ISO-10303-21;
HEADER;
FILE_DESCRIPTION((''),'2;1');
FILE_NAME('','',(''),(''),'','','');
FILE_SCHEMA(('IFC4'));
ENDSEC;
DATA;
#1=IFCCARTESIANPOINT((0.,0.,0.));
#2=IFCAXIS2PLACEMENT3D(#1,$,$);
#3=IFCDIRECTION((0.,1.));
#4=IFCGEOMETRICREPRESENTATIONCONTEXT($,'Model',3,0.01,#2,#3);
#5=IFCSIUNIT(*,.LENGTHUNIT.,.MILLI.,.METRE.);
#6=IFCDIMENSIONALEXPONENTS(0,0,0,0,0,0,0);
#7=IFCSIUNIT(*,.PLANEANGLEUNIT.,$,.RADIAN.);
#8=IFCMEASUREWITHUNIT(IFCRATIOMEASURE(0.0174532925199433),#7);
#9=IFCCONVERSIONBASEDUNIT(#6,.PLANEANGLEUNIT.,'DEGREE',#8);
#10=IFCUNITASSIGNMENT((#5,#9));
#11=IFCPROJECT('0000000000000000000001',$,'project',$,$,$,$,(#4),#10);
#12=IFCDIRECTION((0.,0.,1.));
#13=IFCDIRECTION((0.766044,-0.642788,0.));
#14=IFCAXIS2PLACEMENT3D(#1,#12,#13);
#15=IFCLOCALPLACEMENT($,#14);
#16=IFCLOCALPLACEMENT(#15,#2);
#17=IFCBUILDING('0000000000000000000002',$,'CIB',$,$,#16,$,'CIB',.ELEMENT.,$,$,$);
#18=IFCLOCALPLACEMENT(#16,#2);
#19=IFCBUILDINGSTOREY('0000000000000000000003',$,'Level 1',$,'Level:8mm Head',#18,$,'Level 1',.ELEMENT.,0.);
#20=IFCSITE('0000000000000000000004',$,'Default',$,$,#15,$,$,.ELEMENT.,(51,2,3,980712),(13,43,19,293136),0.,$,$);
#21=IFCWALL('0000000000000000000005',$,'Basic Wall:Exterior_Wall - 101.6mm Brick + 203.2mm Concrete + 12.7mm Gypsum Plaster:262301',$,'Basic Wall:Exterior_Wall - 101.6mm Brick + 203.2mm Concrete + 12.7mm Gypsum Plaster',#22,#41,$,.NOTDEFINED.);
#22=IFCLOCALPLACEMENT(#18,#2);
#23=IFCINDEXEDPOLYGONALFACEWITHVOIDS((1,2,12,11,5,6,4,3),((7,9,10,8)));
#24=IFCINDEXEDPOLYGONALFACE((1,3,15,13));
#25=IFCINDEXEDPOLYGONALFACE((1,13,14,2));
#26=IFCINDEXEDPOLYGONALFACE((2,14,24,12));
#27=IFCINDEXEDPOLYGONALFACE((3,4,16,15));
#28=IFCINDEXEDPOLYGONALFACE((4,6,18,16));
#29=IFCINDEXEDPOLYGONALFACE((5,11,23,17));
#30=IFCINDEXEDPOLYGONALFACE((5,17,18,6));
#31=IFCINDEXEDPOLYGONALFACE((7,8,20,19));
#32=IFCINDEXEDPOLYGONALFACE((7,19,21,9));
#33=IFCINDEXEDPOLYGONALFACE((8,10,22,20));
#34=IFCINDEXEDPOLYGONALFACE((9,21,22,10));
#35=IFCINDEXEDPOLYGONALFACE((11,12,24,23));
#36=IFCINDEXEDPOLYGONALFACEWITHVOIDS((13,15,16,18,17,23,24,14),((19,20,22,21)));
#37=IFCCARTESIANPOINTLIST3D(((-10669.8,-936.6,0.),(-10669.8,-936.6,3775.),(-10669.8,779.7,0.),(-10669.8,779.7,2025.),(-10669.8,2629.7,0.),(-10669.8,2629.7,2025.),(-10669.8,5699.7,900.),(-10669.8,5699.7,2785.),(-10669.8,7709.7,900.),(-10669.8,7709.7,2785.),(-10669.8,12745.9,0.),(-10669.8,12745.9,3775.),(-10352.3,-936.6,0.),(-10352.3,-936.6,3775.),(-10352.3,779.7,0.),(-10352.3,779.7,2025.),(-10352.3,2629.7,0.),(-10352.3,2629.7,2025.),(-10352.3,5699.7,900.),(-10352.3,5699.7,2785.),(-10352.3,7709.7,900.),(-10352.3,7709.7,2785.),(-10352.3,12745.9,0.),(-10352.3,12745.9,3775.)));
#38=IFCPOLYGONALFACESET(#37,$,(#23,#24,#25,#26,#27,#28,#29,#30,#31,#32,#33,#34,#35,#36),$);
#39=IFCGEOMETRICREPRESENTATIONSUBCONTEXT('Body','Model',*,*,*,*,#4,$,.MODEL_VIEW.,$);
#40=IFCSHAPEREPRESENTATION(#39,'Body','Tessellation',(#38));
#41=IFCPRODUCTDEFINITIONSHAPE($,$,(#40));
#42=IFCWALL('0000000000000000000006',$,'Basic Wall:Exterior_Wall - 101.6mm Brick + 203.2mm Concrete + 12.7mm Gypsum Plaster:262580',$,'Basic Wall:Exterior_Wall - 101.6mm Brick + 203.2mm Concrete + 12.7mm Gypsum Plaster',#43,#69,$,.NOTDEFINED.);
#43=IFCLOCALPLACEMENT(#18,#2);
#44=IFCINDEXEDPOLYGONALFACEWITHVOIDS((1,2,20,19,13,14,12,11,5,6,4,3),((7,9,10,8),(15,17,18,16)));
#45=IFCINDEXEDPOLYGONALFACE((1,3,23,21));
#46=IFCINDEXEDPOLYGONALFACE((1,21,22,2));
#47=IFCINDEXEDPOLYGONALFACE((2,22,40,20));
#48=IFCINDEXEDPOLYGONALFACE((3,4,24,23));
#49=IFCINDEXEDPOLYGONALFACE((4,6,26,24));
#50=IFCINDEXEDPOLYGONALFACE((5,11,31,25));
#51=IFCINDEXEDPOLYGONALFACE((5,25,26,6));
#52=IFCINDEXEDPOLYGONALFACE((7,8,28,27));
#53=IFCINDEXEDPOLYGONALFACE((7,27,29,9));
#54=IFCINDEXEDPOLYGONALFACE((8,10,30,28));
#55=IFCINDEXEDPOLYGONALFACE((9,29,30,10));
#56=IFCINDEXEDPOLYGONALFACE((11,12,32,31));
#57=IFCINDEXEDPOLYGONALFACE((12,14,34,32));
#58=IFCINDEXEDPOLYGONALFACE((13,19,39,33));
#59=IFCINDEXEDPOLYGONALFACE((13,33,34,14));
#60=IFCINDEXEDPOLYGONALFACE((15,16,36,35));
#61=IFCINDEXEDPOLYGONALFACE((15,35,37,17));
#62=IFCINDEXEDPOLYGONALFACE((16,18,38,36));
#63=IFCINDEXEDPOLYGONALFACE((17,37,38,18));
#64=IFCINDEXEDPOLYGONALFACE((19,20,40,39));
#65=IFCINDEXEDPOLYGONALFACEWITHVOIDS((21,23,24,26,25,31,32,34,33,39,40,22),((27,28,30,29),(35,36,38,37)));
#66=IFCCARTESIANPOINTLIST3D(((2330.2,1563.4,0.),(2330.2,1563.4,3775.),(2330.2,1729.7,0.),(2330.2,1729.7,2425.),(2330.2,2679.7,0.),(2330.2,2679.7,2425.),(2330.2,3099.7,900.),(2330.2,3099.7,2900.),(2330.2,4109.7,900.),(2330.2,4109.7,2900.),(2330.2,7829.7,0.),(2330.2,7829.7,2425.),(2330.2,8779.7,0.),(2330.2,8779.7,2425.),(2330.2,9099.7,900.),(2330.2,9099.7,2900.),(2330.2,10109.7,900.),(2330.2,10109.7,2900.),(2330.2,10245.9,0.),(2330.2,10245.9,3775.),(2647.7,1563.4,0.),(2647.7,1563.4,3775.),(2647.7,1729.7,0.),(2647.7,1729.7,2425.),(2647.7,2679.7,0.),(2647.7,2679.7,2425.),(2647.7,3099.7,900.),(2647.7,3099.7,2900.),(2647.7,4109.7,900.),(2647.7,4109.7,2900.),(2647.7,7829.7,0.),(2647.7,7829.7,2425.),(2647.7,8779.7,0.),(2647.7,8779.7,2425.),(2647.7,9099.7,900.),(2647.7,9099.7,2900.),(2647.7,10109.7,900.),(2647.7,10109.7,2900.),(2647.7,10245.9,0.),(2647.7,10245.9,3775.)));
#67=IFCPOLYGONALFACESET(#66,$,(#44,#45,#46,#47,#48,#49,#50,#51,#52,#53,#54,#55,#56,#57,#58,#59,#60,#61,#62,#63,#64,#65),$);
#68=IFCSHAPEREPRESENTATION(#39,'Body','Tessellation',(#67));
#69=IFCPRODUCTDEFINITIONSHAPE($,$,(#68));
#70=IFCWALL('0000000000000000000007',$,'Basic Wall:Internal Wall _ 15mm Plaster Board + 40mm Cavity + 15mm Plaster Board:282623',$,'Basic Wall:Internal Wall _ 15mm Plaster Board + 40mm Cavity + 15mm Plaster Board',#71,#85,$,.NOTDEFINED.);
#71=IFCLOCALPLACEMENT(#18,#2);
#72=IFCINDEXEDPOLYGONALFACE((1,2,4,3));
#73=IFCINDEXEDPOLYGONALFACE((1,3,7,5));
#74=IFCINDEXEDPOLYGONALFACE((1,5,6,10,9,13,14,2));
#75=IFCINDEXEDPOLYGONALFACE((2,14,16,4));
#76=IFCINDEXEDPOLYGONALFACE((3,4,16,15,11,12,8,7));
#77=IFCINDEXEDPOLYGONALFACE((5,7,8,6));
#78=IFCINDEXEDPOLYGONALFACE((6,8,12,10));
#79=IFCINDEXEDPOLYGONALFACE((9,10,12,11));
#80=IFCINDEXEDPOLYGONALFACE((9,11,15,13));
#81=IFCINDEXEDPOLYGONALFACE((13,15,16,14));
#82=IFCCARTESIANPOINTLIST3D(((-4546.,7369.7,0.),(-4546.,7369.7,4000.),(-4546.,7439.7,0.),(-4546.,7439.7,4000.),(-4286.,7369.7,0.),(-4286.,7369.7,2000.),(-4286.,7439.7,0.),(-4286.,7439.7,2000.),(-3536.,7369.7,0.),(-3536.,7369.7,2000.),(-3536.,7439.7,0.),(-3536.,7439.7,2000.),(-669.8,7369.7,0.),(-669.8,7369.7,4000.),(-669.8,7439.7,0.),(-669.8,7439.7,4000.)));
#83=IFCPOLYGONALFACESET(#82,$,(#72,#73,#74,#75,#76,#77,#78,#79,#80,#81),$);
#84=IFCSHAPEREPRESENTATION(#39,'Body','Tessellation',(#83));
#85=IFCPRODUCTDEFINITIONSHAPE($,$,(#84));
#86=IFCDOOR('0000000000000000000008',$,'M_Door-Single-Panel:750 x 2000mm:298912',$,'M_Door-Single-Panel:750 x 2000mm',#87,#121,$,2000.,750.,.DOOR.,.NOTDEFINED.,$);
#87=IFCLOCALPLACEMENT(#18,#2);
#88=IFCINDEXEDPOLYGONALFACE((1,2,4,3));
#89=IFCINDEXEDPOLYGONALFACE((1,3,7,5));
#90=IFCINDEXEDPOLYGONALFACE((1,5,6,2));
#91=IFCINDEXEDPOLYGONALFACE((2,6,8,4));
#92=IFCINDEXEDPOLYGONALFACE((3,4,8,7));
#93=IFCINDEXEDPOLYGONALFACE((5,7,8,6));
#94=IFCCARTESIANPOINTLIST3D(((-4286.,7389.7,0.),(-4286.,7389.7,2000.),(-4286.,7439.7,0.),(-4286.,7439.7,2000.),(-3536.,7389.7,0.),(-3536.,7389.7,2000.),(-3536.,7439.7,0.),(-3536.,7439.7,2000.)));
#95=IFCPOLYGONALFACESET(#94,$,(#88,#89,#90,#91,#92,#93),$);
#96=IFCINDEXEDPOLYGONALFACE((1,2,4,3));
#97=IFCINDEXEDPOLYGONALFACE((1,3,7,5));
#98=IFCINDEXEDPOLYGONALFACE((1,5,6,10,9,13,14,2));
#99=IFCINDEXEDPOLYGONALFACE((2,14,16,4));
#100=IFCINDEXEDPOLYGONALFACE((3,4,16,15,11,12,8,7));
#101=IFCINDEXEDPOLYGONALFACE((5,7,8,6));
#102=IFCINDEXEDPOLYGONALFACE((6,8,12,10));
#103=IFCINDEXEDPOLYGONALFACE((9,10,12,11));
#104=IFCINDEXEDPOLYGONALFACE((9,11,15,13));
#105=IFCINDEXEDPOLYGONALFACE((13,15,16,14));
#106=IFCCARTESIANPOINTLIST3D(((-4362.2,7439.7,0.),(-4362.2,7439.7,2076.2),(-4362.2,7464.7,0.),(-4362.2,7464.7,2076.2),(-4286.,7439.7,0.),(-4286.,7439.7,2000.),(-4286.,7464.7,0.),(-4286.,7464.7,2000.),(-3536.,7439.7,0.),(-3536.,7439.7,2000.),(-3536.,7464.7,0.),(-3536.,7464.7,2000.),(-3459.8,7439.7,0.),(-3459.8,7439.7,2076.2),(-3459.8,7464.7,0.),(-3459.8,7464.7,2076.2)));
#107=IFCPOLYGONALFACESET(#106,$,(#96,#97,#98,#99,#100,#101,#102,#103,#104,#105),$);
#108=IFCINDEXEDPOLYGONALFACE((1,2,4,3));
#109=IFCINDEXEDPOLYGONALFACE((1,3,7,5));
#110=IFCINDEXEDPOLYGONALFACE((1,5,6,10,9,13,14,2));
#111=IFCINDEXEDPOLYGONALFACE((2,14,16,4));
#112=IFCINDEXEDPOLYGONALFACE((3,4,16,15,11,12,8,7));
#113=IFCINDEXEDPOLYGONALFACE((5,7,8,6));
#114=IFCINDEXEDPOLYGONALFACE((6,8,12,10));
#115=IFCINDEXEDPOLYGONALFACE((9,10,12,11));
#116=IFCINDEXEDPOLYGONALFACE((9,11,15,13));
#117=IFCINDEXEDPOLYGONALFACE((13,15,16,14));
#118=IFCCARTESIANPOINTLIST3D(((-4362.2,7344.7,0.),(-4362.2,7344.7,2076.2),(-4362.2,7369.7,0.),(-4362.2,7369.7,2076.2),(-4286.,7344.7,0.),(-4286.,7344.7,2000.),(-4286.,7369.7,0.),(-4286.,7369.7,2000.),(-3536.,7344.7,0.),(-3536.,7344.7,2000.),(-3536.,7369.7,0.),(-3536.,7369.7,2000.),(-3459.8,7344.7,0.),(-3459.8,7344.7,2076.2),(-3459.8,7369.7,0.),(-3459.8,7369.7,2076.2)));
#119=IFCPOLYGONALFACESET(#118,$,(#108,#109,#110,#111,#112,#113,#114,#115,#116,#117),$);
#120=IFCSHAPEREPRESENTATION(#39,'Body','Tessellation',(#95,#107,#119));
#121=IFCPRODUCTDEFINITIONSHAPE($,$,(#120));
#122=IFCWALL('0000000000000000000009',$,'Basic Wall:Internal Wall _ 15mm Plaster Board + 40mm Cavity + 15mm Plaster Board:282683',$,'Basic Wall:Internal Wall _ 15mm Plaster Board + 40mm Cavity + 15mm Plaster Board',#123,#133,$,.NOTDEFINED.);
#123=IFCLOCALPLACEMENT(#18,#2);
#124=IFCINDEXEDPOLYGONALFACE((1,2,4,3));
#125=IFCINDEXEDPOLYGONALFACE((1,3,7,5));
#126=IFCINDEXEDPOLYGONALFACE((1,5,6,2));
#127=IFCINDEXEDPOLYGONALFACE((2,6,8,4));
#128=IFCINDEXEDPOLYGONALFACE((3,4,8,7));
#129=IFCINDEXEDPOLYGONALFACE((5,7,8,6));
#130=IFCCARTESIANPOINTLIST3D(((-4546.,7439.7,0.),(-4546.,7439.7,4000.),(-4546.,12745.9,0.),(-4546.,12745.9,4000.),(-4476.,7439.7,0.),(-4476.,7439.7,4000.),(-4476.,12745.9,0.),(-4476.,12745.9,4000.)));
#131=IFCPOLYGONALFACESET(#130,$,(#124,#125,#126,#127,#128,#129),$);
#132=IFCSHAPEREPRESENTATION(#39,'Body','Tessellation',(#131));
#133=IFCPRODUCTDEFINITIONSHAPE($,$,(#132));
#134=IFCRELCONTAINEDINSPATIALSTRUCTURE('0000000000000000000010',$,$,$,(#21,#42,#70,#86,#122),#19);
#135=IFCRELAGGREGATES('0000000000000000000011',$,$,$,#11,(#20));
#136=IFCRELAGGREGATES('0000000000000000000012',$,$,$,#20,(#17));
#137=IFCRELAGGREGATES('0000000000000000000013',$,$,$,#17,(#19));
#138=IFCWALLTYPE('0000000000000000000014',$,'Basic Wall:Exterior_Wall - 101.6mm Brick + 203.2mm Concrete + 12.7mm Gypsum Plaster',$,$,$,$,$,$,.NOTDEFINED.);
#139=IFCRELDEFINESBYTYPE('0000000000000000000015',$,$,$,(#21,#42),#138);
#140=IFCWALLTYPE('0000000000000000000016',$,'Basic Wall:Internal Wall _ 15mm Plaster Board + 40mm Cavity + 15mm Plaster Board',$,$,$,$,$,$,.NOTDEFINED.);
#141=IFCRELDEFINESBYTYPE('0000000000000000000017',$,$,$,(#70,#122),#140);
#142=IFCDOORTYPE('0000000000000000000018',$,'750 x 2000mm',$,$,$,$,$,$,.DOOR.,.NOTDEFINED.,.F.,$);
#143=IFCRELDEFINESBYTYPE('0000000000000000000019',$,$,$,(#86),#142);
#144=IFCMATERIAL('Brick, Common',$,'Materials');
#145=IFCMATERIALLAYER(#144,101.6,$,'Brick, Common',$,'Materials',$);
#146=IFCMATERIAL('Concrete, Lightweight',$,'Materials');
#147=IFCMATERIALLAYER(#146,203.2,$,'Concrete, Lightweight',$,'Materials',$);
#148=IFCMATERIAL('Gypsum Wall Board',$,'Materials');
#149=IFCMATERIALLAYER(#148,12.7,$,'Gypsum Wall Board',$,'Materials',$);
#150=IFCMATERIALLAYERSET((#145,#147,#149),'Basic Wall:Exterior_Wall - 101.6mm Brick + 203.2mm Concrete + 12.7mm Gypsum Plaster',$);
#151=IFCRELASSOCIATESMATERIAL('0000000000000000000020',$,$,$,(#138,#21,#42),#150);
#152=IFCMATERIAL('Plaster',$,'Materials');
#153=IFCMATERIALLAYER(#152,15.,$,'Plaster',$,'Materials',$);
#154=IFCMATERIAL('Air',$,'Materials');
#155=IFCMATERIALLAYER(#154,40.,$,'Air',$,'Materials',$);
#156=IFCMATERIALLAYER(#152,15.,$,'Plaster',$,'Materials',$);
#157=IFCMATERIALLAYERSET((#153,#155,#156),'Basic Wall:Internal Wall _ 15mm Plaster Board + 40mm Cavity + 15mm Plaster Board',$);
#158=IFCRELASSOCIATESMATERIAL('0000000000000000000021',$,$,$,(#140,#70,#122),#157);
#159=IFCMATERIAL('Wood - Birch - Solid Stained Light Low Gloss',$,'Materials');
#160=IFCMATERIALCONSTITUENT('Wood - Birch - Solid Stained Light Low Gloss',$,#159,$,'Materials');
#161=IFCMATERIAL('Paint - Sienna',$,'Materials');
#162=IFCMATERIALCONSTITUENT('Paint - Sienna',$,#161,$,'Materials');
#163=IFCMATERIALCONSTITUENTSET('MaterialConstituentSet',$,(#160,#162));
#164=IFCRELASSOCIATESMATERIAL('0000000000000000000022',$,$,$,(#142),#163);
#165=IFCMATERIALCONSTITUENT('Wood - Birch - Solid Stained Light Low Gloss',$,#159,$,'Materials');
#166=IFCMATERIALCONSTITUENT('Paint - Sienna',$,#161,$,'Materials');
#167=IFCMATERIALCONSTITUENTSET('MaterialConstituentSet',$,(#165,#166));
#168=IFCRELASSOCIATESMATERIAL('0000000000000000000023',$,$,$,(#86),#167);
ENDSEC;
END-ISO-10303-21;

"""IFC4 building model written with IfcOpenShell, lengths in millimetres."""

from ifc_helpers import new_model, entity, si_unit, converted_unit, direction, frame, frame_2d, origin, origin_2d_with_axis, place, context, subcontext, project, spatial, polyline, rectangle, outline, extrude, clip, bounded_halfspace, source, transform, mapped, material, layer, layer_set, layer_usage, constituent, constituent_set, type_object, type_shapes, element, fill, save


model = new_model("IFC4")

# Units and contexts
model_context = context("Model", 3, precision=0.01, world=origin(), true_north=direction((0.0, 1.0)))
body_context = subcontext(model_context, "Body", "Model", "MODEL_VIEW")
ifc_project = project(units=[si_unit("LENGTHUNIT", "METRE", prefix="MILLI"), converted_unit("PLANEANGLEUNIT", "DEGREE", entity("IfcRatioMeasure", 0.0174532925199433), si_unit("PLANEANGLEUNIT", "RADIAN"), dimensions=[0, 0, 0, 0, 0, 0, 0])], contexts=[model_context])

# Site, building, storey
site_placement = place(None, frame((0.0, 0.0, 0.0), z_axis=(0.0, 0.0, 1.0), x_axis=(0.766044, -0.642788, 0.0)))
site = spatial("IfcSite", under=ifc_project, at=site_placement, Name="Default", CompositionType="ELEMENT", RefLatitude=(51, 2, 3, 980712), RefLongitude=(13, 43, 19, 293136), RefElevation=0.0)
building_placement = place(site_placement, origin())
building = spatial("IfcBuilding", under=site, at=building_placement, Name="CIB", LongName="CIB", CompositionType="ELEMENT")
storey_placement = place(building_placement, origin())
storey = spatial("IfcBuildingStorey", under=building, at=storey_placement, Name="Level 1", ObjectType="Level:8mm Head", LongName="Level 1", CompositionType="ELEMENT", Elevation=0.0)

# Shared definitions
ifc_material_1 = material(Name="Brick, Common", Category="Materials")
ifc_layer_1 = layer(ifc_material_1, 101.6, Name="Brick, Common", Category="Materials")
ifc_material_2 = material(Name="Concrete, Lightweight", Category="Materials")
ifc_layer_2 = layer(ifc_material_2, 203.2, Name="Concrete, Lightweight", Category="Materials")
ifc_material_3 = material(Name="Gypsum Wall Board", Category="Materials")
ifc_layer_3 = layer(ifc_material_3, 12.7, Name="Gypsum Wall Board", Category="Materials")
ifc_layer_set_1 = layer_set([ifc_layer_1, ifc_layer_2, ifc_layer_3], Name="Basic Wall:Exterior_Wall - 101.6mm Brick + 203.2mm Concrete + 12.7mm Gypsum Plaster")
wall_type_1 = type_object("IfcWallType", Name="Basic Wall:Exterior_Wall - 101.6mm Brick + 203.2mm Concrete + 12.7mm Gypsum Plaster", PredefinedType="NOTDEFINED", material=ifc_layer_set_1)

# Walls, openings
ifc_layer_usage_1 = layer_usage(ifc_layer_set_1, "AXIS2", "NEGATIVE", 158.8)
wall_1_placement = place(storey_placement, frame((-10511.0, -936.6, 0.0), z_axis=(0.0, 0.0, 1.0), x_axis=(0.0, 1.0, 0.0)))
wall_1 = element("IfcWall", 1, at=wall_1_placement, inside=storey, type_object=wall_type_1, material=ifc_layer_usage_1, Name="Basic Wall:Exterior_Wall - 101.6mm Brick + 203.2mm Concrete + 12.7mm Gypsum Plaster:262301", ObjectType="Basic Wall:Exterior_Wall - 101.6mm Brick + 203.2mm Concrete + 12.7mm Gypsum Plaster", PredefinedType="NOTDEFINED", context=body_context, shape_type="Clipping", body=[
    clip(extrude(rectangle(XDim=13682.5, YDim=317.5, at=frame_2d((6841.2, 0.0), x_axis=(-1.0, 0.0))), origin(), (0.0, 0.0, 1.0), 3775.0), bounded_halfspace(frame((0.0, -158.7, 3775.0), z_axis=(0.0, 0.0, -1.0), x_axis=(0.0, -1.0, 0.0)), True, frame((0.0, -158.7, 3775.0)), polyline([(0.0, 0.0), (13682.5, 0.0), (13682.5, 317.5), (0.0, 317.5), (0.0, 0.0)]))),
])
opening_1_placement = place(wall_1_placement, frame((3566.2, 158.7, 0.0)))
element("IfcOpeningElement", 2, at=opening_1_placement, cuts=wall_1, ObjectType="Opening", PredefinedType="OPENING", context=body_context, shape_type="SweptSolid", body=[
    extrude(rectangle(XDim=2025.0, YDim=1850.0, at=frame_2d((1012.5, 925.0), x_axis=(1.0, 0.0))), frame((0.0, 0.0, 0.0), z_axis=(0.0, -1.0, 0.0), x_axis=(0.0, 0.0, 1.0)), (0.0, 0.0, 1.0), 317.5),
])
opening_2_placement = place(wall_1_placement, frame((8646.2, 158.7, 900.0)))
element("IfcOpeningElement", 3, at=opening_2_placement, cuts=wall_1, ObjectType="Opening", PredefinedType="OPENING", context=body_context, shape_type="SweptSolid", body=[
    extrude(rectangle(XDim=1885.0, YDim=2010.0, at=frame_2d((942.5, 1005.0), x_axis=(1.0, 0.0))), frame((0.0, 0.0, 0.0), z_axis=(0.0, -1.0, 0.0), x_axis=(0.0, 0.0, 1.0)), (0.0, 0.0, 1.0), 317.5),
])
ifc_layer_usage_2 = layer_usage(ifc_layer_set_1, "AXIS2", "NEGATIVE", 158.8)
wall_2_placement = place(storey_placement, frame((2489.0, 10245.9, 0.0), z_axis=(0.0, 0.0, 1.0), x_axis=(0.0, -1.0, 0.0)))
wall_2 = element("IfcWall", 4, at=wall_2_placement, inside=storey, type_object=wall_type_1, material=ifc_layer_usage_2, Name="Basic Wall:Exterior_Wall - 101.6mm Brick + 203.2mm Concrete + 12.7mm Gypsum Plaster:262580", ObjectType="Basic Wall:Exterior_Wall - 101.6mm Brick + 203.2mm Concrete + 12.7mm Gypsum Plaster", PredefinedType="NOTDEFINED", context=body_context, shape_type="Clipping", body=[
    clip(clip(extrude(rectangle(XDim=8682.5, YDim=317.5, at=frame_2d((4341.2, 0.0), x_axis=(-1.0, 0.0))), origin(), (0.0, 0.0, 1.0), 3775.0), bounded_halfspace(frame((0.0, -158.8, 3775.0), z_axis=(0.0, 0.0, -1.0), x_axis=(0.0, 1.0, 0.0)), True, frame((0.0, -158.8, 3775.0)), polyline([(0.0, 0.0), (2682.5, 0.0), (3000.0, 0.0), (3000.0, 317.5), (0.0, 317.5), (0.0, 0.0)]))), bounded_halfspace(frame((5682.5, -158.8, 3775.0), z_axis=(0.0, 0.0, -1.0), x_axis=(0.0, 1.0, 0.0)), True, frame((5682.5, -158.8, 3775.0)), polyline([(0.0, 0.0), (317.5, 0.0), (3000.0, 0.0), (3000.0, 317.5), (0.0, 317.5), (0.0, 0.0)]))),
])
opening_3_placement = place(wall_2_placement, frame((2416.2, 158.7, 0.0)))
element("IfcOpeningElement", 5, at=opening_3_placement, cuts=wall_2, ObjectType="Opening", PredefinedType="OPENING", context=body_context, shape_type="SweptSolid", body=[
    extrude(rectangle(XDim=2425.0, YDim=950.0, at=frame_2d((1212.5, 475.0), x_axis=(1.0, 0.0))), frame((0.0, 0.0, 0.0), z_axis=(0.0, -1.0, 0.0), x_axis=(0.0, 0.0, 1.0)), (0.0, 0.0, 1.0), 317.5),
])
opening_4_placement = place(wall_2_placement, frame((8516.2, 158.7, 0.0)))
element("IfcOpeningElement", 6, at=opening_4_placement, cuts=wall_2, ObjectType="Opening", PredefinedType="OPENING", context=body_context, shape_type="SweptSolid", body=[
    extrude(rectangle(XDim=2425.0, YDim=950.0, at=frame_2d((1212.5, 475.0), x_axis=(1.0, 0.0))), frame((0.0, 0.0, 0.0), z_axis=(0.0, -1.0, 0.0), x_axis=(0.0, 0.0, 1.0)), (0.0, 0.0, 1.0), 317.5),
])
opening_5_placement = place(wall_2_placement, frame((7146.2, 158.8, 900.0)))
element("IfcOpeningElement", 7, at=opening_5_placement, cuts=wall_2, ObjectType="Opening", PredefinedType="OPENING", context=body_context, shape_type="SweptSolid", body=[
    extrude(rectangle(XDim=2000.0, YDim=1010.0, at=frame_2d((1000.0, 505.0), x_axis=(1.0, 0.0))), frame((0.0, 0.0, 0.0), z_axis=(0.0, -1.0, 0.0), x_axis=(0.0, 0.0, 1.0)), (0.0, 0.0, 1.0), 317.5),
])
opening_6_placement = place(wall_2_placement, frame((1146.3, 158.8, 900.0)))
element("IfcOpeningElement", 8, at=opening_6_placement, cuts=wall_2, ObjectType="Opening", PredefinedType="OPENING", context=body_context, shape_type="SweptSolid", body=[
    extrude(rectangle(XDim=2000.0, YDim=1010.0, at=frame_2d((1000.0, 505.0), x_axis=(1.0, 0.0))), frame((0.0, 0.0, 0.0), z_axis=(0.0, -1.0, 0.0), x_axis=(0.0, 0.0, 1.0)), (0.0, 0.0, 1.0), 317.5),
])

# Wall, opening, door
ifc_material_4 = material(Name="Plaster", Category="Materials")
ifc_layer_4 = layer(ifc_material_4, 15.0, Name="Plaster", Category="Materials")
ifc_material_5 = material(Name="Air", Category="Materials")
ifc_layer_5 = layer(ifc_material_5, 40.0, Name="Air", Category="Materials")
ifc_layer_6 = layer(ifc_material_4, 15.0, Name="Plaster", Category="Materials")
ifc_layer_set_2 = layer_set([ifc_layer_4, ifc_layer_5, ifc_layer_6], Name="Basic Wall:Internal Wall _ 15mm Plaster Board + 40mm Cavity + 15mm Plaster Board")
ifc_layer_usage_3 = layer_usage(ifc_layer_set_2, "AXIS2", "NEGATIVE", 35.0)
wall_type_2 = type_object("IfcWallType", Name="Basic Wall:Internal Wall _ 15mm Plaster Board + 40mm Cavity + 15mm Plaster Board", PredefinedType="NOTDEFINED", material=ifc_layer_set_2)
wall_3_placement = place(storey_placement, frame((-669.8, 7404.7, 0.0), z_axis=(0.0, 0.0, 1.0), x_axis=(-1.0, 0.0, 0.0)))
wall_3 = element("IfcWall", 9, at=wall_3_placement, inside=storey, type_object=wall_type_2, material=ifc_layer_usage_3, Name="Basic Wall:Internal Wall _ 15mm Plaster Board + 40mm Cavity + 15mm Plaster Board:282623", ObjectType="Basic Wall:Internal Wall _ 15mm Plaster Board + 40mm Cavity + 15mm Plaster Board", PredefinedType="NOTDEFINED", context=body_context, shape_type="SweptSolid", body=[
    extrude(rectangle(XDim=3876.2, YDim=70.0, at=frame_2d((1938.1, 0.0), x_axis=(-1.0, 0.0))), origin(), (0.0, 0.0, 1.0), 4000.0),
])
opening_7_placement = place(wall_3_placement, frame((3616.2, 35.0, 0.0)))
opening_7 = element("IfcOpeningElement", 10, at=opening_7_placement, cuts=wall_3, ObjectType="Opening", PredefinedType="OPENING", context=body_context, shape_type="SweptSolid", body=[
    extrude(rectangle(XDim=750.0, YDim=2000.0, at=frame_2d((1000.0, 375.0), x_axis=(0.0, -1.0))), frame((0.0, 0.0, 0.0), z_axis=(0.0, -1.0, 0.0), x_axis=(0.0, 0.0, 1.0)), (0.0, 0.0, 1.0), 70.0),
])
ifc_material_6 = material(Name="Wood - Birch - Solid Stained Light Low Gloss", Category="Materials")
ifc_constituent_1 = constituent(ifc_material_6, Name="Wood - Birch - Solid Stained Light Low Gloss", Category="Materials")
ifc_material_7 = material(Name="Paint - Sienna", Category="Materials")
ifc_constituent_2 = constituent(ifc_material_7, Name="Paint - Sienna", Category="Materials")
ifc_constituent_set_1 = constituent_set(constituents=[ifc_constituent_1, ifc_constituent_2], Name="MaterialConstituentSet")
ifc_constituent_3 = constituent(ifc_material_6, Name="Wood - Birch - Solid Stained Light Low Gloss", Category="Materials")
ifc_constituent_4 = constituent(ifc_material_7, Name="Paint - Sienna", Category="Materials")
ifc_constituent_set_2 = constituent_set(constituents=[ifc_constituent_3, ifc_constituent_4], Name="MaterialConstituentSet")
door_type_1 = type_object("IfcDoorType", Name="750 x 2000mm", OperationType="NOTDEFINED", ParameterTakesPrecedence=False, PredefinedType="DOOR", material=ifc_constituent_set_2)
shared_shape_1 = source(origin(), body_context, "Body", "SweptSolid", [
    extrude(rectangle(XDim=750.0, YDim=50.0, at=origin_2d_with_axis()), frame((375.0, 45.0, 0.0)), (0.0, 0.0, 1.0), 2000.0),
    extrude(outline(polyline([(-451.2, -1057.2), (451.2, -1057.2), (451.2, 1019.0), (375.0, 1019.0), (375.0, -981.0), (-375.0, -981.0), (-375.0, 1019.0), (-451.2, 1019.0), (-451.2, -1057.2)])), frame((375.0, 95.0, 1019.0), z_axis=(0.0, -1.0, 0.0), x_axis=(-1.0, 0.0, 0.0)), (0.0, 0.0, 1.0), 25.0),
    extrude(outline(polyline([(-1057.2, -451.2), (1019.0, -451.2), (1019.0, -375.0), (-981.0, -375.0), (-981.0, 375.0), (1019.0, 375.0), (1019.0, 451.2), (-1057.2, 451.2), (-1057.2, -451.2)])), frame((375.0, 0.0, 1019.0), z_axis=(0.0, -1.0, 0.0), x_axis=(0.0, 0.0, -1.0)), (0.0, 0.0, 1.0), 25.0),
])
type_shapes(door_type_1, [shared_shape_1])
door_1_placement = place(opening_7_placement, frame((0.0, 0.0, 0.0), z_axis=(0.0, 0.0, 1.0), x_axis=(-1.0, 0.0, 0.0)))
door_1 = element("IfcDoor", 11, at=door_1_placement, inside=storey, type_object=door_type_1, material=ifc_constituent_set_1, Name="M_Door-Single-Panel:750 x 2000mm:298912", ObjectType="M_Door-Single-Panel:750 x 2000mm", OperationType="NOTDEFINED", OverallHeight=2000.0, OverallWidth=750.0, PredefinedType="DOOR", context=body_context, shape_type="MappedRepresentation", body=[
    mapped(shared_shape_1, transform((0.0, 0.0, 0.0), scale=1.0)),
])
fill(opening_7, door_1)

# Wall
ifc_layer_usage_4 = layer_usage(ifc_layer_set_2, "AXIS2", "NEGATIVE", 35.0)
wall_4_placement = place(storey_placement, frame((-4511.0, 7439.7, 0.0), z_axis=(0.0, 0.0, 1.0), x_axis=(0.0, 1.0, 0.0)))
element("IfcWall", 12, at=wall_4_placement, inside=storey, type_object=wall_type_2, material=ifc_layer_usage_4, Name="Basic Wall:Internal Wall _ 15mm Plaster Board + 40mm Cavity + 15mm Plaster Board:282683", ObjectType="Basic Wall:Internal Wall _ 15mm Plaster Board + 40mm Cavity + 15mm Plaster Board", PredefinedType="NOTDEFINED", context=body_context, shape_type="SweptSolid", body=[
    extrude(rectangle(XDim=5306.2, YDim=70.0, at=frame_2d((2653.1, 0.0), x_axis=(-1.0, 0.0))), origin(), (0.0, 0.0, 1.0), 4000.0),
])

save(model, "model.ifc")
